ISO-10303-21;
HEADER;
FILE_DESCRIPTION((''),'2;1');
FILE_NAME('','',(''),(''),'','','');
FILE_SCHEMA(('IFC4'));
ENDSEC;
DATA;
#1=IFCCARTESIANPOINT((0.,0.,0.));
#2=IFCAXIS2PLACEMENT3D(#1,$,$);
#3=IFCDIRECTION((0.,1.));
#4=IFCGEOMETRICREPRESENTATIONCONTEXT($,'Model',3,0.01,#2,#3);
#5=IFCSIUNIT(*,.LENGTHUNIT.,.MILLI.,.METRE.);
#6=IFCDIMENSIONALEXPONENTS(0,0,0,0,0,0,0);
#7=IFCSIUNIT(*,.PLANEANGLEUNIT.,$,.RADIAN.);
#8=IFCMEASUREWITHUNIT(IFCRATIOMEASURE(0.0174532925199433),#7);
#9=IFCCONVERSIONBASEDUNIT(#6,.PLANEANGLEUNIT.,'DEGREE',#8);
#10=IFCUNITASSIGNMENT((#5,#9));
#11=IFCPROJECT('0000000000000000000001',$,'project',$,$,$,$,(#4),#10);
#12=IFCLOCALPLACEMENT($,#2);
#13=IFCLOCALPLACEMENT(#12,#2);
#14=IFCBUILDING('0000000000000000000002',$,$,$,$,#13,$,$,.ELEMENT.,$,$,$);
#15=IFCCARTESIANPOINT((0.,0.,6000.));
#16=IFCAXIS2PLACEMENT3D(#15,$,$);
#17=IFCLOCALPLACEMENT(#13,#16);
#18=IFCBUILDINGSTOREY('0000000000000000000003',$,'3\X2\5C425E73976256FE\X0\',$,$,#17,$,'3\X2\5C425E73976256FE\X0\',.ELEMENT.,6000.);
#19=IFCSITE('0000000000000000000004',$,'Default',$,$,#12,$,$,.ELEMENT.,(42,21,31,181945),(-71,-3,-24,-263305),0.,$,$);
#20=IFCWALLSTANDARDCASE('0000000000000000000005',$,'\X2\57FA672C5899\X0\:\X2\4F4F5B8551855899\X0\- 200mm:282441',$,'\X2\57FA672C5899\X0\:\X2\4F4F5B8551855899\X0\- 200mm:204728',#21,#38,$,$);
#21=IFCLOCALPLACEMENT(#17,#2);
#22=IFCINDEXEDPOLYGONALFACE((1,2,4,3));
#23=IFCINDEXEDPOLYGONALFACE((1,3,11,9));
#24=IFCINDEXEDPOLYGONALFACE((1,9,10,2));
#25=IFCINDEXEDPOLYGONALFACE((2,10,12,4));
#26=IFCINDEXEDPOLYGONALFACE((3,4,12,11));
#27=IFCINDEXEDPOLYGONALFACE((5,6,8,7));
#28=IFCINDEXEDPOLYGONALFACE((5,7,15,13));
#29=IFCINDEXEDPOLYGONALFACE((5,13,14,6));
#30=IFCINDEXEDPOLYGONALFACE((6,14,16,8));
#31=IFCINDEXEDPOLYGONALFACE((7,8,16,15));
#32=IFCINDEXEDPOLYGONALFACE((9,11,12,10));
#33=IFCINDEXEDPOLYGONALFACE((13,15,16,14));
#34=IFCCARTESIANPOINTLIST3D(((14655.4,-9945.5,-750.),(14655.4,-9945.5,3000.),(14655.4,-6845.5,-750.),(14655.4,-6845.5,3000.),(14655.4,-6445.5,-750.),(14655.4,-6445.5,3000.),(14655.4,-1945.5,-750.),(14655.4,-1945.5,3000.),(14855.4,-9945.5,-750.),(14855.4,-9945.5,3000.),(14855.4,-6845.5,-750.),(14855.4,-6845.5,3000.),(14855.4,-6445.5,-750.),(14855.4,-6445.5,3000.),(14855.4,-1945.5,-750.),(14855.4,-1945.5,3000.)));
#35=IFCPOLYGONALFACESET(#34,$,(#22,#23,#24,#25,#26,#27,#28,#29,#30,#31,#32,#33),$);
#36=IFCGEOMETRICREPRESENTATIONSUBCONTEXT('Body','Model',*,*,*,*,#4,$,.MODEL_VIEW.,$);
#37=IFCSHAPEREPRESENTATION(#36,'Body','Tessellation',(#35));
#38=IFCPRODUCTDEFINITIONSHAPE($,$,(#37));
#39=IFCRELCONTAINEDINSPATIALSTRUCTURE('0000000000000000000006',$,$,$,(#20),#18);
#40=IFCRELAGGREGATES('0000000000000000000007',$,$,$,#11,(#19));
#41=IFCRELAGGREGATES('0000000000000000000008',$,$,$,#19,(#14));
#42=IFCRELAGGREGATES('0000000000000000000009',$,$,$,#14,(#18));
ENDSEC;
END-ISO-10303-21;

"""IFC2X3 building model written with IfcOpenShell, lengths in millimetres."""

from ifc_helpers import new_model, entity, si_unit, converted_unit, direction, frame, frame_2d, origin, place, context, subcontext, project, spatial, polyline, rectangle, extrude, clip, bounded_halfspace, element, save


model = new_model("IFC2X3")

# Units and contexts
model_context = context("Model", 3, precision=0.01, world=origin(), true_north=direction((0.0, 1.0)))
body_context = subcontext(model_context, "Body", "Model", "MODEL_VIEW")
ifc_project = project(units=[si_unit("LENGTHUNIT", "METRE", prefix="MILLI"), converted_unit("PLANEANGLEUNIT", "DEGREE", entity("IfcRatioMeasure", 0.0174532925199433), si_unit("PLANEANGLEUNIT", "RADIAN"), dimensions=[0, 0, 0, 0, 0, 0, 0])], contexts=[model_context])

# Site, building, storey
site_placement = place(None, origin())
site = spatial("IfcSite", under=ifc_project, at=site_placement, Name="Default", CompositionType="ELEMENT", RefLatitude=(42, 21, 31, 181945), RefLongitude=(-71, -3, -24, -263305), RefElevation=0.0)
building_placement = place(site_placement, origin())
building = spatial("IfcBuilding", under=site, at=building_placement, CompositionType="ELEMENT")
storey_placement = place(building_placement, frame((0.0, 0.0, 6000.0)))
storey = spatial("IfcBuildingStorey", under=building, at=storey_placement, Name="3层平面图", LongName="3层平面图", CompositionType="ELEMENT", Elevation=6000.0)

# Wall, opening
wall_1_placement = place(storey_placement, frame((14755.4, -1945.5, -750.0), z_axis=(0.0, 0.0, 1.0), x_axis=(0.0, -1.0, 0.0)))
wall_1 = element("IfcWallStandardCase", 1, at=wall_1_placement, inside=storey, Name="基本墙:住宅内墙- 200mm:282441", ObjectType="基本墙:住宅内墙- 200mm:204728", context=body_context, shape_type="Clipping", body=[
    clip(extrude(rectangle(XDim=8000.0, YDim=200.0, at=frame_2d((4000.0, 0.0), x_axis=(-1.0, 0.0))), origin(), (0.0, 0.0, 1.0), 3750.0), bounded_halfspace(frame((8000.0, -100.0, 3750.0), z_axis=(1.0, 0.0, 0.0), x_axis=(0.0, 0.0, -1.0)), False, frame((8000.0, -100.0, 3750.0), z_axis=(1.0, 0.0, 0.0), x_axis=(0.0, 0.0, -1.0)), polyline([(0.0, 0.0), (3750.0, 0.0), (3750.0, 200.0), (0.0, 200.0), (0.0, 0.0)]))),
])
opening_1_placement = place(storey_placement, frame((14755.4, -1945.5, -750.0), z_axis=(0.0, 0.0, 1.0), x_axis=(0.0, -1.0, 0.0)))
element("IfcOpeningElement", 2, at=opening_1_placement, cuts=wall_1, ObjectType="Opening", context=body_context, shape_type="SweptSolid", body=[
    extrude(rectangle(XDim=3750.0, YDim=200.0, at=frame_2d((0.0, 0.0), x_axis=(1.0, 0.0))), frame((4900.0, 0.0, 1875.0), z_axis=(-1.0, 0.0, 0.0), x_axis=(0.0, 0.0, 1.0)), (0.0, 0.0, 1.0), 400.0),
])

save(model, "model.ifc")
